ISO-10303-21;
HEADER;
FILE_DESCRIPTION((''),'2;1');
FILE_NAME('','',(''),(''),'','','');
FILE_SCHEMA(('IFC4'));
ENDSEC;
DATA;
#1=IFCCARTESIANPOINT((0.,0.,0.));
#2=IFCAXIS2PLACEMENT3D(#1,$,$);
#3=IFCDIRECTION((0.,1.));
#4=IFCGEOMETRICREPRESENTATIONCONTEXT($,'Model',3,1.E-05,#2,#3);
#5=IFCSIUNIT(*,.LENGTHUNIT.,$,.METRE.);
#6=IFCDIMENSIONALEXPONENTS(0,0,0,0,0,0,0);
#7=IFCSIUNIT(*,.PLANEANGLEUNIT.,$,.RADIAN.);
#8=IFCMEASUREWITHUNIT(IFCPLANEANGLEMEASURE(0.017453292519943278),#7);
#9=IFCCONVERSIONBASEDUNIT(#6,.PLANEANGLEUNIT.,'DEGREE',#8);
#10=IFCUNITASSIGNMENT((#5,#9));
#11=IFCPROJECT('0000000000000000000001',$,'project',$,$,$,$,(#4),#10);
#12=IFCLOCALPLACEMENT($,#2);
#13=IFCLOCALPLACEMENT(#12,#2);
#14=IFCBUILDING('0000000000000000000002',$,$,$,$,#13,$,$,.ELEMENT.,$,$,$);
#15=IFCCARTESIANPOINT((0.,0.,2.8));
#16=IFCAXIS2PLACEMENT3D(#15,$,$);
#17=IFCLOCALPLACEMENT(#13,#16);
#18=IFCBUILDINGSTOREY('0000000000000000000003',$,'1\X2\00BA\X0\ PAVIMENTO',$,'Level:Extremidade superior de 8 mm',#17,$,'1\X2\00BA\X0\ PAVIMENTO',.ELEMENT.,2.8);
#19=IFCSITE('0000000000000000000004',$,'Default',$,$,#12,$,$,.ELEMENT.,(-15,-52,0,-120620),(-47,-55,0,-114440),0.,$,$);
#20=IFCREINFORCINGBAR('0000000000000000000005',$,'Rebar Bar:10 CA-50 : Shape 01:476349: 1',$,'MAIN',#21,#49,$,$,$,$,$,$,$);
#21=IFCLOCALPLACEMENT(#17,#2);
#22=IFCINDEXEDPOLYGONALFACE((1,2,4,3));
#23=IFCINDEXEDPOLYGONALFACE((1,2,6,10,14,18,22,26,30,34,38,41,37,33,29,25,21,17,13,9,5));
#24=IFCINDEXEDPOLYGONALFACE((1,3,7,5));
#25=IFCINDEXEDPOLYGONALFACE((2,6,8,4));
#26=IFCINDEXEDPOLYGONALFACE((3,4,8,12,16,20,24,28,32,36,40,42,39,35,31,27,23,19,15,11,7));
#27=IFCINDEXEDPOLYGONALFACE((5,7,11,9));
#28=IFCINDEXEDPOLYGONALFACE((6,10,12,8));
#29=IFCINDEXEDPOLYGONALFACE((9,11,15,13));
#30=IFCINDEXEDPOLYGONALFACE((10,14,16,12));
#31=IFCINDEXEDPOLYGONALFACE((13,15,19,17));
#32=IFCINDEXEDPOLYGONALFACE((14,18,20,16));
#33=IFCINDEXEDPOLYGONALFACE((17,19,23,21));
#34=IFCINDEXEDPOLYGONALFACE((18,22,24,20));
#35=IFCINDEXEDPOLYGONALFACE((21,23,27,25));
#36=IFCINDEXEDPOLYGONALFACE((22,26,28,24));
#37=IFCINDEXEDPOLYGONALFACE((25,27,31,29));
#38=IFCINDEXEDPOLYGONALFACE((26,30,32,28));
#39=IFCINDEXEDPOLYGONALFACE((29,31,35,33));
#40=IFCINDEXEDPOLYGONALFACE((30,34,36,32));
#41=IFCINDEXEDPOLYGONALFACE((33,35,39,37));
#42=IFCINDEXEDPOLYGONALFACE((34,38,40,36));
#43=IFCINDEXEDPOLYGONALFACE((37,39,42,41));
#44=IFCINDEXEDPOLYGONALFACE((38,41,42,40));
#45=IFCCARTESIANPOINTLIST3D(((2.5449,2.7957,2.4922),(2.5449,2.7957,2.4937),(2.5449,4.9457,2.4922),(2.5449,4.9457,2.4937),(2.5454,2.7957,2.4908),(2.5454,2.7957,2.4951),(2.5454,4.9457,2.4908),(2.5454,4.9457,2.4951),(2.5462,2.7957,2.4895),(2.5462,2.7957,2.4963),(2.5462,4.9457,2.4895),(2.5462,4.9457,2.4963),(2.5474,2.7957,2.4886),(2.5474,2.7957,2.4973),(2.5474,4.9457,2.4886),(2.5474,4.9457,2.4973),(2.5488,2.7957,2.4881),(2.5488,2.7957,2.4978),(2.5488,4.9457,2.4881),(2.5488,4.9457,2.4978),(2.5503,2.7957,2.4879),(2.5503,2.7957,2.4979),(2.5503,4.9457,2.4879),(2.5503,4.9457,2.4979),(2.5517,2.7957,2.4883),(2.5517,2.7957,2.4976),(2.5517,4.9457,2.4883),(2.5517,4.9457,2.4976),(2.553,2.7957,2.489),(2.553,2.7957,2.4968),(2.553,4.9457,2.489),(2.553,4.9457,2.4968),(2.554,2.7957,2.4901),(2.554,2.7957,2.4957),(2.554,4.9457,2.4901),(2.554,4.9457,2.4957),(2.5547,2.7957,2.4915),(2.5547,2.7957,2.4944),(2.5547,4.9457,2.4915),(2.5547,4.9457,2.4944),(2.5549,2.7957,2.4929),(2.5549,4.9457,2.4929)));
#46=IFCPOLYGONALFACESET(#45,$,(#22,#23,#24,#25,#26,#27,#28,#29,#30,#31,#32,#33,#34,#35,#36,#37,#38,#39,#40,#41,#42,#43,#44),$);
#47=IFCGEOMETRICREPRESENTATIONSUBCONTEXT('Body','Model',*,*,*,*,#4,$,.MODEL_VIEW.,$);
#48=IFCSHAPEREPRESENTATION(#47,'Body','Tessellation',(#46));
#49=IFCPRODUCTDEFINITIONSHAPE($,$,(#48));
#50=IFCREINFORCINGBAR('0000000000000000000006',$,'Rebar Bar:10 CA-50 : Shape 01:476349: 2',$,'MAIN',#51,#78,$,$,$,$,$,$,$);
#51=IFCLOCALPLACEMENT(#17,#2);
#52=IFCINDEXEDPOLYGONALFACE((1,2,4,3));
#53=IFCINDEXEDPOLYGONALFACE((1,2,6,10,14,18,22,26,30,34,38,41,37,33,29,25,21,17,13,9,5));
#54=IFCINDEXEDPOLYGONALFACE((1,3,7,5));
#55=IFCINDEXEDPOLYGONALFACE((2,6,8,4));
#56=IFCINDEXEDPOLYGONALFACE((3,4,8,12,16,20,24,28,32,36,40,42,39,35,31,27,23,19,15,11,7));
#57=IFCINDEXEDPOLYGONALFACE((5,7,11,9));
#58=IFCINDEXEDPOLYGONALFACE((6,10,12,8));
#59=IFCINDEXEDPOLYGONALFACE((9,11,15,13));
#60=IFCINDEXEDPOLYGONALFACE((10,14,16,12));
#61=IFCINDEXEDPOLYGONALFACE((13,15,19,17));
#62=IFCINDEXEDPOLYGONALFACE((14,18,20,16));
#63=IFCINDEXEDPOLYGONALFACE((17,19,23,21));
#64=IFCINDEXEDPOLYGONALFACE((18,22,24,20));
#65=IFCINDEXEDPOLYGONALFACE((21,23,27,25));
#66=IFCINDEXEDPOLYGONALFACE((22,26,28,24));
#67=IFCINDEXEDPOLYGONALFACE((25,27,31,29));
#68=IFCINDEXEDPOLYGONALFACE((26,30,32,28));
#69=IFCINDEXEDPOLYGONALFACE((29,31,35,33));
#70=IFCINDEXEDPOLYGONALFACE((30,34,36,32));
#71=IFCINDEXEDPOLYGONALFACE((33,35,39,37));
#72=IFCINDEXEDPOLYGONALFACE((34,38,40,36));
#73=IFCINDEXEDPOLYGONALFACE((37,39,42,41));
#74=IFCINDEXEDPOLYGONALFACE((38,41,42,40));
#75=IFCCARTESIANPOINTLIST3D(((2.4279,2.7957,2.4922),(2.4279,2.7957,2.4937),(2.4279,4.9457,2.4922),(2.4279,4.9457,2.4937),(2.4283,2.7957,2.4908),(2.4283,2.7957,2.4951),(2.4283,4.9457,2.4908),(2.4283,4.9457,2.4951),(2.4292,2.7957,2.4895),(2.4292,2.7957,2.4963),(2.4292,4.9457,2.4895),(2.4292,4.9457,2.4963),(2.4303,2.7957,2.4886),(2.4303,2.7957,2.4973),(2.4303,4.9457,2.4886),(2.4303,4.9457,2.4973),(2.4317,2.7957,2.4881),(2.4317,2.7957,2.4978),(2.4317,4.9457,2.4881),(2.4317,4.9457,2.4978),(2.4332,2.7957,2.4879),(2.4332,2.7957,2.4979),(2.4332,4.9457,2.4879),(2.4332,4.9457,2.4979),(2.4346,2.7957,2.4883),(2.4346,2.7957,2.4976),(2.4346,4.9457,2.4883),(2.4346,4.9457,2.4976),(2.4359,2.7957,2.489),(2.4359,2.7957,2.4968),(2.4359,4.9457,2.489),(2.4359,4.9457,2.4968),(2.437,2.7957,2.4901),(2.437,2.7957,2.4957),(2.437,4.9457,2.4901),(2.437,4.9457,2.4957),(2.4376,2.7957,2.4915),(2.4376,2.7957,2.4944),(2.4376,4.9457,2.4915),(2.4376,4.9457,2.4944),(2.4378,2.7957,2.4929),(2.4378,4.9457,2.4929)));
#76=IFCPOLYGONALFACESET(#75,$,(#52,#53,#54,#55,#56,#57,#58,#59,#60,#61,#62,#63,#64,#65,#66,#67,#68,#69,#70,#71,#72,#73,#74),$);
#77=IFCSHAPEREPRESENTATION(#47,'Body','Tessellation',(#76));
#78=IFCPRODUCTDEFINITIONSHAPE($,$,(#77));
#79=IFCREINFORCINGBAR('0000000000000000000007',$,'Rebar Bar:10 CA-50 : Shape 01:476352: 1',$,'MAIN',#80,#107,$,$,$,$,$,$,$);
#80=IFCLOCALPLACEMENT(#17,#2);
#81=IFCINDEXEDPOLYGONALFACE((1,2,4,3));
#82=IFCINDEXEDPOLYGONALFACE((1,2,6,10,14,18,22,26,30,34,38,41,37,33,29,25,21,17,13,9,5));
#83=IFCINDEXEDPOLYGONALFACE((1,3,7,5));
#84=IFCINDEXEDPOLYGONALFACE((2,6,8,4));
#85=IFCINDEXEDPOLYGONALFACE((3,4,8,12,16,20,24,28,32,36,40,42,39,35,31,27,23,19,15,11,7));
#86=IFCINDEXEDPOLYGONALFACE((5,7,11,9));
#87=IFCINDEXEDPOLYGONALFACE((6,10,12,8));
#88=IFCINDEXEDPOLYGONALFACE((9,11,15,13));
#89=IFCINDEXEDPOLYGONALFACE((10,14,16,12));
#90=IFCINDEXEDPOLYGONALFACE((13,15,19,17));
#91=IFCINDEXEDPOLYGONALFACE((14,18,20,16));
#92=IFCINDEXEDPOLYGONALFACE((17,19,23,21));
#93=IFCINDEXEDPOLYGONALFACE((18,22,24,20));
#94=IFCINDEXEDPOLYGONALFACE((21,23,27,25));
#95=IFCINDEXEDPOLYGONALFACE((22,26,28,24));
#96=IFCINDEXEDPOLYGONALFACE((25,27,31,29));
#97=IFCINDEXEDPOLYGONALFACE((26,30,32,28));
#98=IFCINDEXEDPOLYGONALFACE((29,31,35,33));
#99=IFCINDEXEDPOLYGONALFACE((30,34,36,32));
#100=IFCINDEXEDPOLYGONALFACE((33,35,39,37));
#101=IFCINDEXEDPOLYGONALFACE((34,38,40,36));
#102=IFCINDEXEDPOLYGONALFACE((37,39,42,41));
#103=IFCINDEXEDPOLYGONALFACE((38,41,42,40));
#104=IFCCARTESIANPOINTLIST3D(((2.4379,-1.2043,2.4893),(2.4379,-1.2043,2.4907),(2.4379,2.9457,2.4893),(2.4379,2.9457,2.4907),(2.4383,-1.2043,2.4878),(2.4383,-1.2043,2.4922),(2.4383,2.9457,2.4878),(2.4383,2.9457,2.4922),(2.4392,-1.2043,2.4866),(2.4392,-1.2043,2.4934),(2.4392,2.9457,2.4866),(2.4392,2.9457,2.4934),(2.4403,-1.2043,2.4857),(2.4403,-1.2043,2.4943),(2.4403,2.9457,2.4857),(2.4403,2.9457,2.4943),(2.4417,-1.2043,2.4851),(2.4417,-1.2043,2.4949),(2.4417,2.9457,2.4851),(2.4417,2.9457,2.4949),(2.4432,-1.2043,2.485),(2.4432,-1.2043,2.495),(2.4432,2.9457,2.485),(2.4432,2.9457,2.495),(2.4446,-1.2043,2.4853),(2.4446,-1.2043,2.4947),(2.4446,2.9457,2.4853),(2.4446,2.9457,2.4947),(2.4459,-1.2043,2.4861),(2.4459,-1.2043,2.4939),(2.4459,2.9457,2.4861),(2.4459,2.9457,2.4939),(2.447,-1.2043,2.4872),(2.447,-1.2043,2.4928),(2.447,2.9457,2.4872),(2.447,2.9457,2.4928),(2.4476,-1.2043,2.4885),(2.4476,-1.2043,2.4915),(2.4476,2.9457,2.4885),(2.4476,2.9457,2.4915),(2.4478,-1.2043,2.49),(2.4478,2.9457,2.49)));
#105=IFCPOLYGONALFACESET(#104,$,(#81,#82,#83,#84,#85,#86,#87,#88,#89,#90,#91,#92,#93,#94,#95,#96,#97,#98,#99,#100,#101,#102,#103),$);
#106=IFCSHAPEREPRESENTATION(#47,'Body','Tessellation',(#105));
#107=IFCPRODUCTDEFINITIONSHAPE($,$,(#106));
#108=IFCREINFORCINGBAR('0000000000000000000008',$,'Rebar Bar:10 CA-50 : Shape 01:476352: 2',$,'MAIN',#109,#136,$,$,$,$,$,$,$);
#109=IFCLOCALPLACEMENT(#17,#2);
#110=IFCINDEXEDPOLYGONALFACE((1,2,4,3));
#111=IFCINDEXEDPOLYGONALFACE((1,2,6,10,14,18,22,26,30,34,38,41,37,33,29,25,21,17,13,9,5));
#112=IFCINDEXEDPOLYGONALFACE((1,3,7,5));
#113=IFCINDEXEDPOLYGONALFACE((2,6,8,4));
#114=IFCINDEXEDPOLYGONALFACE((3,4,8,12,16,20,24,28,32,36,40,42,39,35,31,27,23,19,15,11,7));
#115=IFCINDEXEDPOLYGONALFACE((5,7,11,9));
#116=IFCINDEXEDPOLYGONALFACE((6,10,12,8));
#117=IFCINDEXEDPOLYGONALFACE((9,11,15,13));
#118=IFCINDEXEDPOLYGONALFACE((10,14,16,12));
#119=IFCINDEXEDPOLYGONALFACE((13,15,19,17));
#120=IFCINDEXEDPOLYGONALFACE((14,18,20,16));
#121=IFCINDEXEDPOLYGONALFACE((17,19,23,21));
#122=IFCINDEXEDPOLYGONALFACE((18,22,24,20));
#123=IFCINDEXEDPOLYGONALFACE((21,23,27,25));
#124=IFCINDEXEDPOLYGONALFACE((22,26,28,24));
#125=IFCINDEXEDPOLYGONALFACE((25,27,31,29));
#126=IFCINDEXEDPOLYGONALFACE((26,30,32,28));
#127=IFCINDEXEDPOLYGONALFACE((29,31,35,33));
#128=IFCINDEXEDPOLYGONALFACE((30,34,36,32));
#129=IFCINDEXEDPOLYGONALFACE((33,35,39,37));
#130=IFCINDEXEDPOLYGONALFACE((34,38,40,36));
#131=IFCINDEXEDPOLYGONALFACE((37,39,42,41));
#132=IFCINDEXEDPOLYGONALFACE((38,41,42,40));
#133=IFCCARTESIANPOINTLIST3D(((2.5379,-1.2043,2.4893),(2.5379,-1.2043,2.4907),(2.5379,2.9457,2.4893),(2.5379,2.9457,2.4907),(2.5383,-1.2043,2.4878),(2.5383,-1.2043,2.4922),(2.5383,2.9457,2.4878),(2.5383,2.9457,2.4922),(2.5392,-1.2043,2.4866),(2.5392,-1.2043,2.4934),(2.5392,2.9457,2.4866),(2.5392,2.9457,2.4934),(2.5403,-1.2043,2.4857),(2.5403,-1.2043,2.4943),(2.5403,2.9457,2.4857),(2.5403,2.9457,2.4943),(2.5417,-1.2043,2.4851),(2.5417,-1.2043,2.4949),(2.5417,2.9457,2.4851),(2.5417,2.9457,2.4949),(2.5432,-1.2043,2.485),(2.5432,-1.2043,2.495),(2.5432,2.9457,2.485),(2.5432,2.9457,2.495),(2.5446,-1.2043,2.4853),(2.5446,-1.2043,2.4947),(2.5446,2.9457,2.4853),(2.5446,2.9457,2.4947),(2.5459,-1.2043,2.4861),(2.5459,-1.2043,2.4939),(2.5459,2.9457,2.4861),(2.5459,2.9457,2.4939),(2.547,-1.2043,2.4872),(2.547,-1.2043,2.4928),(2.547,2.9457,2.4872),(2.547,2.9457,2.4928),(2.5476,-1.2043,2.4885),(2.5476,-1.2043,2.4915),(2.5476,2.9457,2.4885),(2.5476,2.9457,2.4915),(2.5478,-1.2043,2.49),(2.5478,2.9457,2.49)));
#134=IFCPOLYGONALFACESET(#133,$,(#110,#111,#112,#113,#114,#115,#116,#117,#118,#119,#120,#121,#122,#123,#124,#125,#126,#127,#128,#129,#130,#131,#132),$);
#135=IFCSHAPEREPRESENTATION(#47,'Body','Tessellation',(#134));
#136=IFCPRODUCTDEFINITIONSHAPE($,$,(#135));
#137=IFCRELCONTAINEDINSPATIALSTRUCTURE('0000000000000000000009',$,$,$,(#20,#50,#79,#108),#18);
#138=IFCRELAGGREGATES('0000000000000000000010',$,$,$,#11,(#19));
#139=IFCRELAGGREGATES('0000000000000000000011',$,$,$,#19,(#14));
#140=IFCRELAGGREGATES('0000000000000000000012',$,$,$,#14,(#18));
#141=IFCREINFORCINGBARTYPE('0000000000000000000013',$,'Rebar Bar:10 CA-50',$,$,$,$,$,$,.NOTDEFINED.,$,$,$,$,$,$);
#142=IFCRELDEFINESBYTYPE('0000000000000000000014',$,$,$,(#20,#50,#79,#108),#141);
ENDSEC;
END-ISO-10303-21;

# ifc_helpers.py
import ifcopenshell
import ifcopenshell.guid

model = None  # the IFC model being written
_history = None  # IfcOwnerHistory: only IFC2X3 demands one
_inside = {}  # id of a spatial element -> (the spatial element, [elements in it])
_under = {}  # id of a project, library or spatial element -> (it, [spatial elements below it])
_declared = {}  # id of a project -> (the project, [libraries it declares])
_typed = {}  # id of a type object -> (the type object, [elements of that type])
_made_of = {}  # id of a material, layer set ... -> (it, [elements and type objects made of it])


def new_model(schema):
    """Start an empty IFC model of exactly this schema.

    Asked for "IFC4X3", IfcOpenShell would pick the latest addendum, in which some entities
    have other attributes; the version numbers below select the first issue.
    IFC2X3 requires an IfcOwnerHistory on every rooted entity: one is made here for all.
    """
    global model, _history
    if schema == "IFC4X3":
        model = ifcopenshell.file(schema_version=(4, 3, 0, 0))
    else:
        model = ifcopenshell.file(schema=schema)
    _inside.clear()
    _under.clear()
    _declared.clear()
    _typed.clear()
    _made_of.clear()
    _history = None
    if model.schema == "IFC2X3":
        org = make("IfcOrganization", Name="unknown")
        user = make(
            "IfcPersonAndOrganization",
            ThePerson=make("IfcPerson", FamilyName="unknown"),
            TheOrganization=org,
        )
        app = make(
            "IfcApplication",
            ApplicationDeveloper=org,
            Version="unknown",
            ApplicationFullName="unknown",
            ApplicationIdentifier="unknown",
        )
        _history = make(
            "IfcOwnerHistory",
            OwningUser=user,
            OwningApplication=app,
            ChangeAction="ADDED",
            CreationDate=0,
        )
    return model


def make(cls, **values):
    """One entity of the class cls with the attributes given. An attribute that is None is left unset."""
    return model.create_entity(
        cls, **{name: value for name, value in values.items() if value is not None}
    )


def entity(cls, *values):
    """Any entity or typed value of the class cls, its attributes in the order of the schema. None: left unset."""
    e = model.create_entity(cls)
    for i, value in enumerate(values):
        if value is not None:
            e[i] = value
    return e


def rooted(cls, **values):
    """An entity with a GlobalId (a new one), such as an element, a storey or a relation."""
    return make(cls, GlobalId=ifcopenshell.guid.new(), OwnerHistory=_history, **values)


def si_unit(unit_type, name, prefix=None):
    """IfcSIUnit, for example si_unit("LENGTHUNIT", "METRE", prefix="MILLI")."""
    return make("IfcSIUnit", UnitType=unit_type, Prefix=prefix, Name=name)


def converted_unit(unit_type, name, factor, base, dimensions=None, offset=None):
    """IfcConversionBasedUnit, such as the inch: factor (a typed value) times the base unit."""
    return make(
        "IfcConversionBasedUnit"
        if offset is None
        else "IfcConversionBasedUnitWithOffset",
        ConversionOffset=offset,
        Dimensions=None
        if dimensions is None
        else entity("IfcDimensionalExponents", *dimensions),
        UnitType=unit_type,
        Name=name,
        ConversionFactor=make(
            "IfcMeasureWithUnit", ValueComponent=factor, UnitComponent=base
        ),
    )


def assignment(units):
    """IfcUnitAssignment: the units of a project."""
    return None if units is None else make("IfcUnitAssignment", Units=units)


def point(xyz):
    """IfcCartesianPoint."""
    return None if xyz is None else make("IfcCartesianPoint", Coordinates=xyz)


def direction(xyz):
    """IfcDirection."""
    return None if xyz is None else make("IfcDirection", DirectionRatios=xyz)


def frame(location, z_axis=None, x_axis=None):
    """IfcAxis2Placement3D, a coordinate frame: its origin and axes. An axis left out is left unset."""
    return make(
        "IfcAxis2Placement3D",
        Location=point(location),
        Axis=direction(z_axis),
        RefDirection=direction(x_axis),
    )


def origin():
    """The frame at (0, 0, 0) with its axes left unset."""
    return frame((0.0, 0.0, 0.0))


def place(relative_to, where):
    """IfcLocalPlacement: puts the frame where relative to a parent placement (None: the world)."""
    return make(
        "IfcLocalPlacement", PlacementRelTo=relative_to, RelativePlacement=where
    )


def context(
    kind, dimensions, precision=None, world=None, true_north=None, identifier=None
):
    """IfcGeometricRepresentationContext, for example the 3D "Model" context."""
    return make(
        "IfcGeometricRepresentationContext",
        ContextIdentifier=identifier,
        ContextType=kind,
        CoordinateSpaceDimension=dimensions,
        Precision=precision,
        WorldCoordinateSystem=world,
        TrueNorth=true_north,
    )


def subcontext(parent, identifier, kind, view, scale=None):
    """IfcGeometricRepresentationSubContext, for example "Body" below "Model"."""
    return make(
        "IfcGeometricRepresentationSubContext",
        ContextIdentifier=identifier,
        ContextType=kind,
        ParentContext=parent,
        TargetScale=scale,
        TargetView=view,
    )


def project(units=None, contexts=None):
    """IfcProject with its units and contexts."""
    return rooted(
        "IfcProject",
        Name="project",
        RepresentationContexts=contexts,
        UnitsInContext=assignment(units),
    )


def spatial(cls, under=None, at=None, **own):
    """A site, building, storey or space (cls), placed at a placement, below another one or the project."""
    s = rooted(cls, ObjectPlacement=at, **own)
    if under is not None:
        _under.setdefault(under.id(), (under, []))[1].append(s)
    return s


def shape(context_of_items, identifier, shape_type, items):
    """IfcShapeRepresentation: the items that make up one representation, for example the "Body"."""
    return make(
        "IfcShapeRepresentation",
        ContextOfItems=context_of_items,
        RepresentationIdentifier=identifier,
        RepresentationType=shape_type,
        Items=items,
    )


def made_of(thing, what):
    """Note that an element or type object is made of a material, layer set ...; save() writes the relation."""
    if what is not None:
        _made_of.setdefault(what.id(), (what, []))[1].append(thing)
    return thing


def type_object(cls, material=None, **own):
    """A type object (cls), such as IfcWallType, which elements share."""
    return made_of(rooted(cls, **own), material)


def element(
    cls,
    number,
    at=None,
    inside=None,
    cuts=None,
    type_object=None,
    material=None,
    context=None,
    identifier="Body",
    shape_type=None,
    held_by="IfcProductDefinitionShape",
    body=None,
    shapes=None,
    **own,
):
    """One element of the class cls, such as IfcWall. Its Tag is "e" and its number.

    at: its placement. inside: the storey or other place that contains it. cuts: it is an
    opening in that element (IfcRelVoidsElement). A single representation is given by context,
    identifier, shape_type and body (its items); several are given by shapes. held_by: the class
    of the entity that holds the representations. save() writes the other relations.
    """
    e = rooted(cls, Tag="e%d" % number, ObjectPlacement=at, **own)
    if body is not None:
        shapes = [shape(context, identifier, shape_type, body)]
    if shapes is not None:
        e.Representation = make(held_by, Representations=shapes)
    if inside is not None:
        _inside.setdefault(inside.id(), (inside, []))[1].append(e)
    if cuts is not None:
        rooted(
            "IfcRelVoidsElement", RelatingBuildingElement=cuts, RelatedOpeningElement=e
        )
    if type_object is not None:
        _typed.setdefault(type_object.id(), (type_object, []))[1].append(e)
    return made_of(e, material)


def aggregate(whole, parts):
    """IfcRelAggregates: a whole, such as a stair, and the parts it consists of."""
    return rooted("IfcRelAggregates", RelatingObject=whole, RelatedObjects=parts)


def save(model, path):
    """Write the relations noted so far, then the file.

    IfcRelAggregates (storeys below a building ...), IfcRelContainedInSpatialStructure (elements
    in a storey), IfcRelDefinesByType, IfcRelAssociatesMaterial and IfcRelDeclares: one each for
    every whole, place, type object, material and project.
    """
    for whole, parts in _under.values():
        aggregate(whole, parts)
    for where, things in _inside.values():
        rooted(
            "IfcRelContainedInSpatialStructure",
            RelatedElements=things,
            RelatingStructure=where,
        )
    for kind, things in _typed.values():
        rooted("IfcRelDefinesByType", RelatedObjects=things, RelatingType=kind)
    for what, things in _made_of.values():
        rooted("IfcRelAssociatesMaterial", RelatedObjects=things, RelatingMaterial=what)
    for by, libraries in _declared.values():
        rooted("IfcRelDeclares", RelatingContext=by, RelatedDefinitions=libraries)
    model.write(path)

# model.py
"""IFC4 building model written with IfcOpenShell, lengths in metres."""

from ifc_helpers import new_model, entity, si_unit, converted_unit, direction, frame, origin, place, context, subcontext, project, spatial, type_object, element, save


model = new_model("IFC4")

# Units and contexts
model_context = context("Model", 3, precision=1e-05, world=origin(), true_north=direction((0.0, 1.0)))
body_context = subcontext(model_context, "Body", "Model", "MODEL_VIEW")
ifc_project = project(units=[si_unit("LENGTHUNIT", "METRE"), converted_unit("PLANEANGLEUNIT", "DEGREE", entity("IfcPlaneAngleMeasure", 0.017453292519943278), si_unit("PLANEANGLEUNIT", "RADIAN"), dimensions=[0, 0, 0, 0, 0, 0, 0])], contexts=[model_context])

# Site, building, storey
site_placement = place(None, origin())
site = spatial("IfcSite", under=ifc_project, at=site_placement, Name="Default", CompositionType="ELEMENT", RefLatitude=(-15, -52, 0, -120620), RefLongitude=(-47, -55, 0, -114440), RefElevation=0.0)
building_placement = place(site_placement, origin())
building = spatial("IfcBuilding", under=site, at=building_placement, CompositionType="ELEMENT")
storey_placement = place(building_placement, frame((0.0, 0.0, 2.8)))
storey = spatial("IfcBuildingStorey", under=building, at=storey_placement, Name="1º PAVIMENTO", ObjectType="Level:Extremidade superior de 8 mm", LongName="1º PAVIMENTO", CompositionType="ELEMENT", Elevation=2.8)

# Reinforcing bars
reinforcing_bar_type = type_object("IfcReinforcingBarType", Name="Rebar Bar:10 CA-50", PredefinedType="NOTDEFINED")
reinforcing_bar_1_placement = place(storey_placement, origin())
element("IfcReinforcingBar", 1, at=reinforcing_bar_1_placement, inside=storey, type_object=reinforcing_bar_type, Name="Rebar Bar:10 CA-50 : Shape 01:476349: 1", ObjectType="MAIN", context=body_context, shape_type="AdvancedSweptSolid", body=[
    entity("IfcSweptDiskSolid", entity("IfcIndexedPolyCurve", entity("IfcCartesianPointList3D", [[2.5499, 2.7957, 2.4929], [2.5499, 4.9457, 2.4929]]), None, False), 0.005, None, 0.0, 1.0),
])
reinforcing_bar_2_placement = place(storey_placement, origin())
element("IfcReinforcingBar", 2, at=reinforcing_bar_2_placement, inside=storey, type_object=reinforcing_bar_type, Name="Rebar Bar:10 CA-50 : Shape 01:476349: 2", ObjectType="MAIN", context=body_context, shape_type="AdvancedSweptSolid", body=[
    entity("IfcSweptDiskSolid", entity("IfcIndexedPolyCurve", entity("IfcCartesianPointList3D", [[2.4328, 2.7957, 2.4929], [2.4328, 4.9457, 2.4929]]), None, False), 0.005, None, 0.0, 1.0),
])
reinforcing_bar_3_placement = place(storey_placement, origin())
element("IfcReinforcingBar", 3, at=reinforcing_bar_3_placement, inside=storey, type_object=reinforcing_bar_type, Name="Rebar Bar:10 CA-50 : Shape 01:476352: 1", ObjectType="MAIN", context=body_context, shape_type="AdvancedSweptSolid", body=[
    entity("IfcSweptDiskSolid", entity("IfcIndexedPolyCurve", entity("IfcCartesianPointList3D", [[2.4428, -1.2043, 2.49], [2.4428, 2.9457, 2.49]]), None, False), 0.005, None, 0.0, 1.0),
])
reinforcing_bar_4_placement = place(storey_placement, origin())
element("IfcReinforcingBar", 4, at=reinforcing_bar_4_placement, inside=storey, type_object=reinforcing_bar_type, Name="Rebar Bar:10 CA-50 : Shape 01:476352: 2", ObjectType="MAIN", context=body_context, shape_type="AdvancedSweptSolid", body=[
    entity("IfcSweptDiskSolid", entity("IfcIndexedPolyCurve", entity("IfcCartesianPointList3D", [[2.5428, -1.2043, 2.49], [2.5428, 2.9457, 2.49]]), None, False), 0.005, None, 0.0, 1.0),
])

save(model, "model.ifc")
